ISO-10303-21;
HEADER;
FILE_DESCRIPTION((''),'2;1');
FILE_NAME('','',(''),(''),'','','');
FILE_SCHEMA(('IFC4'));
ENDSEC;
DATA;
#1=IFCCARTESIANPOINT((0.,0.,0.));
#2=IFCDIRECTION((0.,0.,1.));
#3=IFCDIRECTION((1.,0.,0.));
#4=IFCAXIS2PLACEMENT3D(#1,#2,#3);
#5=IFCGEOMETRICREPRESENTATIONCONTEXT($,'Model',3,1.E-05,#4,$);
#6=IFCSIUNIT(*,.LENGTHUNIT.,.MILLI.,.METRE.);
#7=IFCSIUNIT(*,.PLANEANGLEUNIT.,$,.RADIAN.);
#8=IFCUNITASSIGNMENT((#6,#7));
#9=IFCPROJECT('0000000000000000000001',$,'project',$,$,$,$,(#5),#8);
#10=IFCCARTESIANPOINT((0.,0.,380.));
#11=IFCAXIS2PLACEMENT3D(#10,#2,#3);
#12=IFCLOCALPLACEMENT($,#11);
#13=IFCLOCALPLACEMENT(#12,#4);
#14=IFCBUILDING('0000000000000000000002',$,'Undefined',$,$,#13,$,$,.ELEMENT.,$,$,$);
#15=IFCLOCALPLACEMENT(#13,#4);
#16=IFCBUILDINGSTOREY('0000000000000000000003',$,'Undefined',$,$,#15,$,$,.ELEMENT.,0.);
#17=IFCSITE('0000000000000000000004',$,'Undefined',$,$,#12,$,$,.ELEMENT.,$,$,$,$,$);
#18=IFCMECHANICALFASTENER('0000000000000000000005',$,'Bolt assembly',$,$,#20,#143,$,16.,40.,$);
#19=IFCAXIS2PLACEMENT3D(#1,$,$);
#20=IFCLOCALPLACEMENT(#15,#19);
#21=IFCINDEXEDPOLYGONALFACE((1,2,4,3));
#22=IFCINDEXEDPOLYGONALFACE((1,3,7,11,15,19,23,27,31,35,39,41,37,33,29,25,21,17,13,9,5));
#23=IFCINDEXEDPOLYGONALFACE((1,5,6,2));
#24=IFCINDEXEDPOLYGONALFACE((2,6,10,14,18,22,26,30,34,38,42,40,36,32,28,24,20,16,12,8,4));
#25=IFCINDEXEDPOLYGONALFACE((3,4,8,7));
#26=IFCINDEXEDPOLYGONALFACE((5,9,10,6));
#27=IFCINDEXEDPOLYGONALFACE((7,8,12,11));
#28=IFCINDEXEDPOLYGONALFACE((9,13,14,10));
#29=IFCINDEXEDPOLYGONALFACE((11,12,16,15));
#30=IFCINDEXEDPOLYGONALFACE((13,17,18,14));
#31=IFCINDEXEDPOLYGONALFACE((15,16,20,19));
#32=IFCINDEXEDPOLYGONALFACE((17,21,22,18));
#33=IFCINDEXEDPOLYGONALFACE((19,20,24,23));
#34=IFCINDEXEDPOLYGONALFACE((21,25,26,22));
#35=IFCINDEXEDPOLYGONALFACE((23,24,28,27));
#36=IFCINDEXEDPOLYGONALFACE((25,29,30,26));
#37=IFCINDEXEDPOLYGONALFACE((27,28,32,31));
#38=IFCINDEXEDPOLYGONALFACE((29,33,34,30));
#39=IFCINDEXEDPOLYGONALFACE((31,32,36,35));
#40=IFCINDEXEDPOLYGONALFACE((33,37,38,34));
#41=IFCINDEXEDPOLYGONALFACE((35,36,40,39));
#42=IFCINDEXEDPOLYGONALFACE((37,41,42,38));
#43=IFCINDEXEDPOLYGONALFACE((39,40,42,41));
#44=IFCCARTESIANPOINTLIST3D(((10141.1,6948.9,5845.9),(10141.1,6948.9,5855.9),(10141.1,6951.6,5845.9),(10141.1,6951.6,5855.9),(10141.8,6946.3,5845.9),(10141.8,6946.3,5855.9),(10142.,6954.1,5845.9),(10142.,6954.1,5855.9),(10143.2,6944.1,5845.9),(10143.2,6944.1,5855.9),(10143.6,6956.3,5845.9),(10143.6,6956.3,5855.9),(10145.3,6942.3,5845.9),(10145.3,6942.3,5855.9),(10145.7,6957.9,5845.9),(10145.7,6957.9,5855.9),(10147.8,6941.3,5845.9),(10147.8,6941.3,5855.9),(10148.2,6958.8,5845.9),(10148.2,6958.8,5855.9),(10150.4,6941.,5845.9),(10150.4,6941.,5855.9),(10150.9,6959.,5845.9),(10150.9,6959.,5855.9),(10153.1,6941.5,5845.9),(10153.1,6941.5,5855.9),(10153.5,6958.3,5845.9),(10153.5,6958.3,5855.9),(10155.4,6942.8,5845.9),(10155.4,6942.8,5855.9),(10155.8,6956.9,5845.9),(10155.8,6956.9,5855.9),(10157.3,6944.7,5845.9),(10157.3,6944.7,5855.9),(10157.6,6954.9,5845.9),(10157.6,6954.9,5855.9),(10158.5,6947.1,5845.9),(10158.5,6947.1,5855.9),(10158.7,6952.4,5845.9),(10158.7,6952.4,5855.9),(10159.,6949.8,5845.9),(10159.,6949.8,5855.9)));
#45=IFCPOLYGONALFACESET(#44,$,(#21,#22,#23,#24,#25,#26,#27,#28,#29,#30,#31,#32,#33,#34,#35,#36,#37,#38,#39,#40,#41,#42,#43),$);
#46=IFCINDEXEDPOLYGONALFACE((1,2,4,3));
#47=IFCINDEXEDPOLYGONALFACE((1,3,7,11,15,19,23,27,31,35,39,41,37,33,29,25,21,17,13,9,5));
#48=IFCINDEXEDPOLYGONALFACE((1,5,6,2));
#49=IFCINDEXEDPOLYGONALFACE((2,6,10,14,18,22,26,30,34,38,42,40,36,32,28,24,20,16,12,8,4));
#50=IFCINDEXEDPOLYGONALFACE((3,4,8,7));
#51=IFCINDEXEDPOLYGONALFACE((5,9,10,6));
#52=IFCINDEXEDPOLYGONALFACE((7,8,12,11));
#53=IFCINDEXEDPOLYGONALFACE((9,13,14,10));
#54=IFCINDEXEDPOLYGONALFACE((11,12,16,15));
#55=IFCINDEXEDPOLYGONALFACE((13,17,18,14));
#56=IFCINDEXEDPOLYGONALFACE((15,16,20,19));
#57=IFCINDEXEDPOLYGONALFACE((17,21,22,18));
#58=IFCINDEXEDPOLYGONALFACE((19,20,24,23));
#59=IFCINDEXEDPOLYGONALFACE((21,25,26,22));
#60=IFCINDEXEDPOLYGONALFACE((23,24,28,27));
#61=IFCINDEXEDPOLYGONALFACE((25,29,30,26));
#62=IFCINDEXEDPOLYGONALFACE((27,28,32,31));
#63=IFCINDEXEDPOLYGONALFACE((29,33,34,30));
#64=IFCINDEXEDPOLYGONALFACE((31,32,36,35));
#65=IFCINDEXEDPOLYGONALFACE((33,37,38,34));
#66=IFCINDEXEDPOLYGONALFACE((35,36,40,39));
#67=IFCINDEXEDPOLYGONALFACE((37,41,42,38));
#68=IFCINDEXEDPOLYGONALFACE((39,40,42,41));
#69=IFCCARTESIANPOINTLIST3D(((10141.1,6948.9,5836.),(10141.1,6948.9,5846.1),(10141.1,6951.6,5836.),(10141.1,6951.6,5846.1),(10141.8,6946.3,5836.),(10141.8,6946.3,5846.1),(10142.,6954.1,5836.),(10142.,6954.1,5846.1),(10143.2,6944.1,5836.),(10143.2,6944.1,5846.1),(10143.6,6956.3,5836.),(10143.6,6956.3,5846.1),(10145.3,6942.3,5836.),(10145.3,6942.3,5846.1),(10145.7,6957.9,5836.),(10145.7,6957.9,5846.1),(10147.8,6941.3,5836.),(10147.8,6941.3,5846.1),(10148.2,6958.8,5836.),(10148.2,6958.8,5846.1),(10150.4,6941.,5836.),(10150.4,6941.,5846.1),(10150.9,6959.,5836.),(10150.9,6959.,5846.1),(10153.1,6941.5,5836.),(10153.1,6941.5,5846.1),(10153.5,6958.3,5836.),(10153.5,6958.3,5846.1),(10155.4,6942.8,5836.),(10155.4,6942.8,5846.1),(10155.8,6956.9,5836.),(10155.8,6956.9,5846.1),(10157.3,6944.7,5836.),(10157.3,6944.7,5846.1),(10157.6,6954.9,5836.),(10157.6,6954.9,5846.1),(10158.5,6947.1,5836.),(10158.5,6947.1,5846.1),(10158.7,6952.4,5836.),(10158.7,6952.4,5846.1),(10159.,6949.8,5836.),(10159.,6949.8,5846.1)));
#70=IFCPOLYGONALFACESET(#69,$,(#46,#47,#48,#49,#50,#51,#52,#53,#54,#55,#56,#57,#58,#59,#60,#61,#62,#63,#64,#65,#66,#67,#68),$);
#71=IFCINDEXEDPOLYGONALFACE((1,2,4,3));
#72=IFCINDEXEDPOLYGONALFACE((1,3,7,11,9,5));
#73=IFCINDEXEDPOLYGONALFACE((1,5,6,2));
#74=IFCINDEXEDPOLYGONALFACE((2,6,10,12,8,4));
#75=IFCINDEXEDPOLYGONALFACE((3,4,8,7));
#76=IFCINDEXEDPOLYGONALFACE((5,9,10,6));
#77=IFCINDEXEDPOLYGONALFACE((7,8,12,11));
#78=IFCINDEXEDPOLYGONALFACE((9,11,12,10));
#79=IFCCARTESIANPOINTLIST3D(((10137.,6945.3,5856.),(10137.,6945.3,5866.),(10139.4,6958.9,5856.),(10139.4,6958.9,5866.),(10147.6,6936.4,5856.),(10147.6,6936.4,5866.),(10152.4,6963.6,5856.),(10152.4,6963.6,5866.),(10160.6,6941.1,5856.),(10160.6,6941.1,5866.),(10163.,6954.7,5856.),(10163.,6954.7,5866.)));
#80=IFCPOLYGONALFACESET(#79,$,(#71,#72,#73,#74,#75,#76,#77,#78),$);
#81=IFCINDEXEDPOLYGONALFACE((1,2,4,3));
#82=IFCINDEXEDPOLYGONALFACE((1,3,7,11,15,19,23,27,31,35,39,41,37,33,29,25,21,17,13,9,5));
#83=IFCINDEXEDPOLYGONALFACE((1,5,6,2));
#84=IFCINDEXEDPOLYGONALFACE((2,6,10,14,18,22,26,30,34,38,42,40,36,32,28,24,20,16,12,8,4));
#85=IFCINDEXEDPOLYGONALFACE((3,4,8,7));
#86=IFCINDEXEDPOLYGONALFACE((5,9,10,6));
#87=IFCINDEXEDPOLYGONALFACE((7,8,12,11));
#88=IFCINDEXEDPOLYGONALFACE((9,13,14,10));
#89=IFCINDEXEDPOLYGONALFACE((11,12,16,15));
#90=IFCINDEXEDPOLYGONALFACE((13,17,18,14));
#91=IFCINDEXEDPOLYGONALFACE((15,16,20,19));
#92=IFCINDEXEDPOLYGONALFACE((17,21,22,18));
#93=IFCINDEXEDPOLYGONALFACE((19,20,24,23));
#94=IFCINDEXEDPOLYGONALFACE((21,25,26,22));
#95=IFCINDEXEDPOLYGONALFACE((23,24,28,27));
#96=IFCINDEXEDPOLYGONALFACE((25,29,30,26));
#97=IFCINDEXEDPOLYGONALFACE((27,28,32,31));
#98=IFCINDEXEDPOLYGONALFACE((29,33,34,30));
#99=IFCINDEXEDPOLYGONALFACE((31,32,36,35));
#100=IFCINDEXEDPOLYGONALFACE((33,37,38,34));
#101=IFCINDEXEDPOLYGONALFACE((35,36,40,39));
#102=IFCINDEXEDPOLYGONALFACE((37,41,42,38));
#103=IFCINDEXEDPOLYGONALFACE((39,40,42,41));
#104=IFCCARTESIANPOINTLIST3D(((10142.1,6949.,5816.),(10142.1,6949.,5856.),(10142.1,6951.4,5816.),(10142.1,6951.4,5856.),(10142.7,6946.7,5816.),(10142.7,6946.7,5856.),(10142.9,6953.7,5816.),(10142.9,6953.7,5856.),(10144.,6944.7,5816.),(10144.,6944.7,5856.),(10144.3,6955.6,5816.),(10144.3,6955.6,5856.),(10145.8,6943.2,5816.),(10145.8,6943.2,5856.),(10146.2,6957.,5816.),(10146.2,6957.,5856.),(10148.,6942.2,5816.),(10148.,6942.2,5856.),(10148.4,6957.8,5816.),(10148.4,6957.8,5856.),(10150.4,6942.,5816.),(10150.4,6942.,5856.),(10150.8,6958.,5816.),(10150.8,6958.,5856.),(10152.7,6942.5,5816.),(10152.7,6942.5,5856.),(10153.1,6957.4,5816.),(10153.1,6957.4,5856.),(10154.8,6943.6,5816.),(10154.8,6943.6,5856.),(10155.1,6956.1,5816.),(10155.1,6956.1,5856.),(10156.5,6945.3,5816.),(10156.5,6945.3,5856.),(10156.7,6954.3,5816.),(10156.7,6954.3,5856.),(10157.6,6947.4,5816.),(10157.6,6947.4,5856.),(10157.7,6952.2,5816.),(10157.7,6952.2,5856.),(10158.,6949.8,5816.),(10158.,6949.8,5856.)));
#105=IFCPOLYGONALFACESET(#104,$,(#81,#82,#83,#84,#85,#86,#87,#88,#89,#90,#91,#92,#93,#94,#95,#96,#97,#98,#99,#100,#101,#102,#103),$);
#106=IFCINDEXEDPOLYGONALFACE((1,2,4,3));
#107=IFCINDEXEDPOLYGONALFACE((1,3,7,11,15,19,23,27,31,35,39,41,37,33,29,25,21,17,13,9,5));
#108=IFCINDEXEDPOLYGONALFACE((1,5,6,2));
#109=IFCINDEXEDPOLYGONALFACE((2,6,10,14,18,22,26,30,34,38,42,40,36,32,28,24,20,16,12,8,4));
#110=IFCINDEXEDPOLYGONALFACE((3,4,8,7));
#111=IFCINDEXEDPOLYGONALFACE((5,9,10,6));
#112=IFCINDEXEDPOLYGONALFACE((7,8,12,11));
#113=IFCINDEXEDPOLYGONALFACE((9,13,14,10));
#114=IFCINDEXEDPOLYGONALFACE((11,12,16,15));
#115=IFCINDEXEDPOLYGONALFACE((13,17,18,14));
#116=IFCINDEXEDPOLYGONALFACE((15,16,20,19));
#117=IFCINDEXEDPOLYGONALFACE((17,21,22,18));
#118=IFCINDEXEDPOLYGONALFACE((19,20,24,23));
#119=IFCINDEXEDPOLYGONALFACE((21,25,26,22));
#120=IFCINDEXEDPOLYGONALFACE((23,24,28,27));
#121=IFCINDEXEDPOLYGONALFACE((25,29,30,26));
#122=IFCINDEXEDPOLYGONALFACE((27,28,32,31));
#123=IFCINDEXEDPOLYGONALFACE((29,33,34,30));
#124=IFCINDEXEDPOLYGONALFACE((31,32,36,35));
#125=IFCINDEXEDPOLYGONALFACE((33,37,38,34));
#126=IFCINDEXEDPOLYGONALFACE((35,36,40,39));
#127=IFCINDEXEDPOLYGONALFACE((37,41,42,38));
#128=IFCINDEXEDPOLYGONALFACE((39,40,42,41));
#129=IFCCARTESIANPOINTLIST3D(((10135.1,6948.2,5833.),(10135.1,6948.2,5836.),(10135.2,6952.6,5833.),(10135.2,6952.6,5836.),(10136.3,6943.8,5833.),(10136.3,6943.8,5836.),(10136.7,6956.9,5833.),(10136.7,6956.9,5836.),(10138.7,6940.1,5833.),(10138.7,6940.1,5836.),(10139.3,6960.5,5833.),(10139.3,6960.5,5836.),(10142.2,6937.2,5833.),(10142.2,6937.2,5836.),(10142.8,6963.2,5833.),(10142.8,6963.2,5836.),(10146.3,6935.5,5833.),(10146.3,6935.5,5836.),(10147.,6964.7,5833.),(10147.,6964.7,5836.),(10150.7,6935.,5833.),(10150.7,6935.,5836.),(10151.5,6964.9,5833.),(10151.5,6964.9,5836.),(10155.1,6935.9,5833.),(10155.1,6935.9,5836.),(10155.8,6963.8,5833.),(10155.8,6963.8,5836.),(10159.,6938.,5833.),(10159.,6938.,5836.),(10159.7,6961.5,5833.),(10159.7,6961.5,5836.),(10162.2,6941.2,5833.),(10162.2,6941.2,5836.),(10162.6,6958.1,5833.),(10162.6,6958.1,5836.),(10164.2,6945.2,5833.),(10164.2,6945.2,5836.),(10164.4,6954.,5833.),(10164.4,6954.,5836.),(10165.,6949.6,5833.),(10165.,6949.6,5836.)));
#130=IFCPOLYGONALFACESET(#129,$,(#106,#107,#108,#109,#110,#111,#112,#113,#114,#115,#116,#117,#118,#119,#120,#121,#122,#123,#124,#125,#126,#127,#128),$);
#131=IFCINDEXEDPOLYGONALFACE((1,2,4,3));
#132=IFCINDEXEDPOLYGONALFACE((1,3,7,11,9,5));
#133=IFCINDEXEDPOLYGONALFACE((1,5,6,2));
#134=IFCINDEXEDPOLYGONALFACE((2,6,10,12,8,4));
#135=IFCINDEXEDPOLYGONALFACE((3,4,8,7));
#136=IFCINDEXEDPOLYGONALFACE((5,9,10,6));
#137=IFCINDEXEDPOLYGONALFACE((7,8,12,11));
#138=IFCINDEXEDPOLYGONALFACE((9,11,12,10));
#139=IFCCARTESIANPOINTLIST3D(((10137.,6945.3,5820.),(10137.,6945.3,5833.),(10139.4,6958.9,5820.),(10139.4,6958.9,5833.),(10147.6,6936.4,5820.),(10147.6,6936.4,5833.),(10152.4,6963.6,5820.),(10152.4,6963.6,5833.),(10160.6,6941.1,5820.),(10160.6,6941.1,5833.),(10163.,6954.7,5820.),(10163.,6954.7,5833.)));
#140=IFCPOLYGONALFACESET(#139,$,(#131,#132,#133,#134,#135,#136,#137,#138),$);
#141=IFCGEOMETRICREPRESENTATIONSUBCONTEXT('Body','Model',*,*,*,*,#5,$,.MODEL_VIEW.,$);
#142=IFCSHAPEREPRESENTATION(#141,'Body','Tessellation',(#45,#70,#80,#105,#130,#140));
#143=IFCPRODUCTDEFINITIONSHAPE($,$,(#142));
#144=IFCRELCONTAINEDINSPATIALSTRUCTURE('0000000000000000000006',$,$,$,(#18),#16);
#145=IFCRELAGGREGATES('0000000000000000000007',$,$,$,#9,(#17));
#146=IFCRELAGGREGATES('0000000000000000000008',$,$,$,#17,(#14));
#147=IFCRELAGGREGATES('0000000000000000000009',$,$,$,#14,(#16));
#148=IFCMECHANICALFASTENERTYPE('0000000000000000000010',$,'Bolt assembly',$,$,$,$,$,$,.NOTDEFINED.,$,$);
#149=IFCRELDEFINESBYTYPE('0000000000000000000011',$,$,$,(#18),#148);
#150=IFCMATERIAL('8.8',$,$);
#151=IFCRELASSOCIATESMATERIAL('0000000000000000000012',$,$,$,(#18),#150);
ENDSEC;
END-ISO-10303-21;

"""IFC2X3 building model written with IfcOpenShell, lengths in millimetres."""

from ifc_helpers import new_model, si_unit, frame, origin_with_axes, origin_2d_with_axis, place, context, subcontext, project, spatial, polyline, circle, outline, extrude, source, transform, mapped, material, type_object, element, save


model = new_model("IFC2X3")

# Units and contexts
model_context = context("Model", 3, precision=1e-05, world=origin_with_axes())
body_context = subcontext(model_context, "Body", "Model", "MODEL_VIEW")
ifc_project = project(units=[si_unit("LENGTHUNIT", "METRE", prefix="MILLI"), si_unit("PLANEANGLEUNIT", "RADIAN")], contexts=[model_context])

# Site, building, storey
site_placement = place(None, frame((0.0, 0.0, 380.0), z_axis=(0.0, 0.0, 1.0), x_axis=(1.0, 0.0, 0.0)))
site = spatial("IfcSite", under=ifc_project, at=site_placement, Name="Undefined", CompositionType="ELEMENT")
building_placement = place(site_placement, origin_with_axes())
building = spatial("IfcBuilding", under=site, at=building_placement, Name="Undefined", CompositionType="ELEMENT")
storey_placement = place(building_placement, origin_with_axes())
storey = spatial("IfcBuildingStorey", under=building, at=storey_placement, Name="Undefined", CompositionType="ELEMENT", Elevation=0.0)

# Mechanical fastener
ifc_material_1 = material(Name="8.8")
mechanical_fastener_type = type_object("IfcMechanicalFastenerType", Name="Bolt assembly")
shared_shape_1 = source(origin_with_axes(), body_context, "Body", "SweptSolid", [
    extrude(circle(Radius=9.0, at=origin_2d_with_axis()), frame((0.0, -4.9, 0.0), z_axis=(0.0, 1.0, 0.0), x_axis=(1.0, 0.0, 0.0)), (0.0, 0.0, 1.0), 10.0),
    extrude(circle(Radius=9.0, at=origin_2d_with_axis()), frame((0.0, 4.9, 0.0), z_axis=(0.0, 1.0, 0.0), x_axis=(1.0, 0.0, 0.0)), (0.0, 0.0, 1.0), 10.1),
    extrude(outline(polyline([(12.0, -6.9), (12.0, 6.9), (0.0, 13.9), (-12.0, 6.9), (-12.0, -6.9), (0.0, -13.9), (12.0, -6.9)])), frame((0.0, -15.0, 0.0), z_axis=(0.0, 1.0, 0.0), x_axis=(1.0, 0.0, 0.0)), (0.0, 0.0, 1.0), 10.0),
    extrude(circle(Radius=8.0, at=origin_2d_with_axis()), frame((0.0, -5.0, 0.0), z_axis=(0.0, 1.0, 0.0), x_axis=(1.0, 0.0, 0.0)), (0.0, 0.0, 1.0), 40.0),
    extrude(circle(Radius=15.0, at=origin_2d_with_axis()), frame((0.0, 15.0, 0.0), z_axis=(0.0, 1.0, 0.0), x_axis=(1.0, 0.0, 0.0)), (0.0, 0.0, 1.0), 3.0),
    extrude(outline(polyline([(12.0, -6.9), (12.0, 6.9), (0.0, 13.9), (-12.0, 6.9), (-12.0, -6.9), (0.0, -13.9), (12.0, -6.9)])), frame((0.0, 18.0, 0.0), z_axis=(0.0, 1.0, 0.0), x_axis=(1.0, 0.0, 0.0)), (0.0, 0.0, 1.0), 13.0),
])
mechanical_fastener_1_placement = place(storey_placement, frame((10150.0, 6950.0, 5851.0), z_axis=(-0.765362, 0.6436, 0.0), x_axis=(0.6436, 0.765362, 0.0)))
element("IfcMechanicalFastener", 1, at=mechanical_fastener_1_placement, inside=storey, type_object=mechanical_fastener_type, material=ifc_material_1, Name="Bolt assembly", NominalDiameter=16.0, NominalLength=40.0, context=body_context, shape_type="MappedRepresentation", body=[
    mapped(shared_shape_1, transform((0.0, 0.0, 0.0))),
])

save(model, "model.ifc")
